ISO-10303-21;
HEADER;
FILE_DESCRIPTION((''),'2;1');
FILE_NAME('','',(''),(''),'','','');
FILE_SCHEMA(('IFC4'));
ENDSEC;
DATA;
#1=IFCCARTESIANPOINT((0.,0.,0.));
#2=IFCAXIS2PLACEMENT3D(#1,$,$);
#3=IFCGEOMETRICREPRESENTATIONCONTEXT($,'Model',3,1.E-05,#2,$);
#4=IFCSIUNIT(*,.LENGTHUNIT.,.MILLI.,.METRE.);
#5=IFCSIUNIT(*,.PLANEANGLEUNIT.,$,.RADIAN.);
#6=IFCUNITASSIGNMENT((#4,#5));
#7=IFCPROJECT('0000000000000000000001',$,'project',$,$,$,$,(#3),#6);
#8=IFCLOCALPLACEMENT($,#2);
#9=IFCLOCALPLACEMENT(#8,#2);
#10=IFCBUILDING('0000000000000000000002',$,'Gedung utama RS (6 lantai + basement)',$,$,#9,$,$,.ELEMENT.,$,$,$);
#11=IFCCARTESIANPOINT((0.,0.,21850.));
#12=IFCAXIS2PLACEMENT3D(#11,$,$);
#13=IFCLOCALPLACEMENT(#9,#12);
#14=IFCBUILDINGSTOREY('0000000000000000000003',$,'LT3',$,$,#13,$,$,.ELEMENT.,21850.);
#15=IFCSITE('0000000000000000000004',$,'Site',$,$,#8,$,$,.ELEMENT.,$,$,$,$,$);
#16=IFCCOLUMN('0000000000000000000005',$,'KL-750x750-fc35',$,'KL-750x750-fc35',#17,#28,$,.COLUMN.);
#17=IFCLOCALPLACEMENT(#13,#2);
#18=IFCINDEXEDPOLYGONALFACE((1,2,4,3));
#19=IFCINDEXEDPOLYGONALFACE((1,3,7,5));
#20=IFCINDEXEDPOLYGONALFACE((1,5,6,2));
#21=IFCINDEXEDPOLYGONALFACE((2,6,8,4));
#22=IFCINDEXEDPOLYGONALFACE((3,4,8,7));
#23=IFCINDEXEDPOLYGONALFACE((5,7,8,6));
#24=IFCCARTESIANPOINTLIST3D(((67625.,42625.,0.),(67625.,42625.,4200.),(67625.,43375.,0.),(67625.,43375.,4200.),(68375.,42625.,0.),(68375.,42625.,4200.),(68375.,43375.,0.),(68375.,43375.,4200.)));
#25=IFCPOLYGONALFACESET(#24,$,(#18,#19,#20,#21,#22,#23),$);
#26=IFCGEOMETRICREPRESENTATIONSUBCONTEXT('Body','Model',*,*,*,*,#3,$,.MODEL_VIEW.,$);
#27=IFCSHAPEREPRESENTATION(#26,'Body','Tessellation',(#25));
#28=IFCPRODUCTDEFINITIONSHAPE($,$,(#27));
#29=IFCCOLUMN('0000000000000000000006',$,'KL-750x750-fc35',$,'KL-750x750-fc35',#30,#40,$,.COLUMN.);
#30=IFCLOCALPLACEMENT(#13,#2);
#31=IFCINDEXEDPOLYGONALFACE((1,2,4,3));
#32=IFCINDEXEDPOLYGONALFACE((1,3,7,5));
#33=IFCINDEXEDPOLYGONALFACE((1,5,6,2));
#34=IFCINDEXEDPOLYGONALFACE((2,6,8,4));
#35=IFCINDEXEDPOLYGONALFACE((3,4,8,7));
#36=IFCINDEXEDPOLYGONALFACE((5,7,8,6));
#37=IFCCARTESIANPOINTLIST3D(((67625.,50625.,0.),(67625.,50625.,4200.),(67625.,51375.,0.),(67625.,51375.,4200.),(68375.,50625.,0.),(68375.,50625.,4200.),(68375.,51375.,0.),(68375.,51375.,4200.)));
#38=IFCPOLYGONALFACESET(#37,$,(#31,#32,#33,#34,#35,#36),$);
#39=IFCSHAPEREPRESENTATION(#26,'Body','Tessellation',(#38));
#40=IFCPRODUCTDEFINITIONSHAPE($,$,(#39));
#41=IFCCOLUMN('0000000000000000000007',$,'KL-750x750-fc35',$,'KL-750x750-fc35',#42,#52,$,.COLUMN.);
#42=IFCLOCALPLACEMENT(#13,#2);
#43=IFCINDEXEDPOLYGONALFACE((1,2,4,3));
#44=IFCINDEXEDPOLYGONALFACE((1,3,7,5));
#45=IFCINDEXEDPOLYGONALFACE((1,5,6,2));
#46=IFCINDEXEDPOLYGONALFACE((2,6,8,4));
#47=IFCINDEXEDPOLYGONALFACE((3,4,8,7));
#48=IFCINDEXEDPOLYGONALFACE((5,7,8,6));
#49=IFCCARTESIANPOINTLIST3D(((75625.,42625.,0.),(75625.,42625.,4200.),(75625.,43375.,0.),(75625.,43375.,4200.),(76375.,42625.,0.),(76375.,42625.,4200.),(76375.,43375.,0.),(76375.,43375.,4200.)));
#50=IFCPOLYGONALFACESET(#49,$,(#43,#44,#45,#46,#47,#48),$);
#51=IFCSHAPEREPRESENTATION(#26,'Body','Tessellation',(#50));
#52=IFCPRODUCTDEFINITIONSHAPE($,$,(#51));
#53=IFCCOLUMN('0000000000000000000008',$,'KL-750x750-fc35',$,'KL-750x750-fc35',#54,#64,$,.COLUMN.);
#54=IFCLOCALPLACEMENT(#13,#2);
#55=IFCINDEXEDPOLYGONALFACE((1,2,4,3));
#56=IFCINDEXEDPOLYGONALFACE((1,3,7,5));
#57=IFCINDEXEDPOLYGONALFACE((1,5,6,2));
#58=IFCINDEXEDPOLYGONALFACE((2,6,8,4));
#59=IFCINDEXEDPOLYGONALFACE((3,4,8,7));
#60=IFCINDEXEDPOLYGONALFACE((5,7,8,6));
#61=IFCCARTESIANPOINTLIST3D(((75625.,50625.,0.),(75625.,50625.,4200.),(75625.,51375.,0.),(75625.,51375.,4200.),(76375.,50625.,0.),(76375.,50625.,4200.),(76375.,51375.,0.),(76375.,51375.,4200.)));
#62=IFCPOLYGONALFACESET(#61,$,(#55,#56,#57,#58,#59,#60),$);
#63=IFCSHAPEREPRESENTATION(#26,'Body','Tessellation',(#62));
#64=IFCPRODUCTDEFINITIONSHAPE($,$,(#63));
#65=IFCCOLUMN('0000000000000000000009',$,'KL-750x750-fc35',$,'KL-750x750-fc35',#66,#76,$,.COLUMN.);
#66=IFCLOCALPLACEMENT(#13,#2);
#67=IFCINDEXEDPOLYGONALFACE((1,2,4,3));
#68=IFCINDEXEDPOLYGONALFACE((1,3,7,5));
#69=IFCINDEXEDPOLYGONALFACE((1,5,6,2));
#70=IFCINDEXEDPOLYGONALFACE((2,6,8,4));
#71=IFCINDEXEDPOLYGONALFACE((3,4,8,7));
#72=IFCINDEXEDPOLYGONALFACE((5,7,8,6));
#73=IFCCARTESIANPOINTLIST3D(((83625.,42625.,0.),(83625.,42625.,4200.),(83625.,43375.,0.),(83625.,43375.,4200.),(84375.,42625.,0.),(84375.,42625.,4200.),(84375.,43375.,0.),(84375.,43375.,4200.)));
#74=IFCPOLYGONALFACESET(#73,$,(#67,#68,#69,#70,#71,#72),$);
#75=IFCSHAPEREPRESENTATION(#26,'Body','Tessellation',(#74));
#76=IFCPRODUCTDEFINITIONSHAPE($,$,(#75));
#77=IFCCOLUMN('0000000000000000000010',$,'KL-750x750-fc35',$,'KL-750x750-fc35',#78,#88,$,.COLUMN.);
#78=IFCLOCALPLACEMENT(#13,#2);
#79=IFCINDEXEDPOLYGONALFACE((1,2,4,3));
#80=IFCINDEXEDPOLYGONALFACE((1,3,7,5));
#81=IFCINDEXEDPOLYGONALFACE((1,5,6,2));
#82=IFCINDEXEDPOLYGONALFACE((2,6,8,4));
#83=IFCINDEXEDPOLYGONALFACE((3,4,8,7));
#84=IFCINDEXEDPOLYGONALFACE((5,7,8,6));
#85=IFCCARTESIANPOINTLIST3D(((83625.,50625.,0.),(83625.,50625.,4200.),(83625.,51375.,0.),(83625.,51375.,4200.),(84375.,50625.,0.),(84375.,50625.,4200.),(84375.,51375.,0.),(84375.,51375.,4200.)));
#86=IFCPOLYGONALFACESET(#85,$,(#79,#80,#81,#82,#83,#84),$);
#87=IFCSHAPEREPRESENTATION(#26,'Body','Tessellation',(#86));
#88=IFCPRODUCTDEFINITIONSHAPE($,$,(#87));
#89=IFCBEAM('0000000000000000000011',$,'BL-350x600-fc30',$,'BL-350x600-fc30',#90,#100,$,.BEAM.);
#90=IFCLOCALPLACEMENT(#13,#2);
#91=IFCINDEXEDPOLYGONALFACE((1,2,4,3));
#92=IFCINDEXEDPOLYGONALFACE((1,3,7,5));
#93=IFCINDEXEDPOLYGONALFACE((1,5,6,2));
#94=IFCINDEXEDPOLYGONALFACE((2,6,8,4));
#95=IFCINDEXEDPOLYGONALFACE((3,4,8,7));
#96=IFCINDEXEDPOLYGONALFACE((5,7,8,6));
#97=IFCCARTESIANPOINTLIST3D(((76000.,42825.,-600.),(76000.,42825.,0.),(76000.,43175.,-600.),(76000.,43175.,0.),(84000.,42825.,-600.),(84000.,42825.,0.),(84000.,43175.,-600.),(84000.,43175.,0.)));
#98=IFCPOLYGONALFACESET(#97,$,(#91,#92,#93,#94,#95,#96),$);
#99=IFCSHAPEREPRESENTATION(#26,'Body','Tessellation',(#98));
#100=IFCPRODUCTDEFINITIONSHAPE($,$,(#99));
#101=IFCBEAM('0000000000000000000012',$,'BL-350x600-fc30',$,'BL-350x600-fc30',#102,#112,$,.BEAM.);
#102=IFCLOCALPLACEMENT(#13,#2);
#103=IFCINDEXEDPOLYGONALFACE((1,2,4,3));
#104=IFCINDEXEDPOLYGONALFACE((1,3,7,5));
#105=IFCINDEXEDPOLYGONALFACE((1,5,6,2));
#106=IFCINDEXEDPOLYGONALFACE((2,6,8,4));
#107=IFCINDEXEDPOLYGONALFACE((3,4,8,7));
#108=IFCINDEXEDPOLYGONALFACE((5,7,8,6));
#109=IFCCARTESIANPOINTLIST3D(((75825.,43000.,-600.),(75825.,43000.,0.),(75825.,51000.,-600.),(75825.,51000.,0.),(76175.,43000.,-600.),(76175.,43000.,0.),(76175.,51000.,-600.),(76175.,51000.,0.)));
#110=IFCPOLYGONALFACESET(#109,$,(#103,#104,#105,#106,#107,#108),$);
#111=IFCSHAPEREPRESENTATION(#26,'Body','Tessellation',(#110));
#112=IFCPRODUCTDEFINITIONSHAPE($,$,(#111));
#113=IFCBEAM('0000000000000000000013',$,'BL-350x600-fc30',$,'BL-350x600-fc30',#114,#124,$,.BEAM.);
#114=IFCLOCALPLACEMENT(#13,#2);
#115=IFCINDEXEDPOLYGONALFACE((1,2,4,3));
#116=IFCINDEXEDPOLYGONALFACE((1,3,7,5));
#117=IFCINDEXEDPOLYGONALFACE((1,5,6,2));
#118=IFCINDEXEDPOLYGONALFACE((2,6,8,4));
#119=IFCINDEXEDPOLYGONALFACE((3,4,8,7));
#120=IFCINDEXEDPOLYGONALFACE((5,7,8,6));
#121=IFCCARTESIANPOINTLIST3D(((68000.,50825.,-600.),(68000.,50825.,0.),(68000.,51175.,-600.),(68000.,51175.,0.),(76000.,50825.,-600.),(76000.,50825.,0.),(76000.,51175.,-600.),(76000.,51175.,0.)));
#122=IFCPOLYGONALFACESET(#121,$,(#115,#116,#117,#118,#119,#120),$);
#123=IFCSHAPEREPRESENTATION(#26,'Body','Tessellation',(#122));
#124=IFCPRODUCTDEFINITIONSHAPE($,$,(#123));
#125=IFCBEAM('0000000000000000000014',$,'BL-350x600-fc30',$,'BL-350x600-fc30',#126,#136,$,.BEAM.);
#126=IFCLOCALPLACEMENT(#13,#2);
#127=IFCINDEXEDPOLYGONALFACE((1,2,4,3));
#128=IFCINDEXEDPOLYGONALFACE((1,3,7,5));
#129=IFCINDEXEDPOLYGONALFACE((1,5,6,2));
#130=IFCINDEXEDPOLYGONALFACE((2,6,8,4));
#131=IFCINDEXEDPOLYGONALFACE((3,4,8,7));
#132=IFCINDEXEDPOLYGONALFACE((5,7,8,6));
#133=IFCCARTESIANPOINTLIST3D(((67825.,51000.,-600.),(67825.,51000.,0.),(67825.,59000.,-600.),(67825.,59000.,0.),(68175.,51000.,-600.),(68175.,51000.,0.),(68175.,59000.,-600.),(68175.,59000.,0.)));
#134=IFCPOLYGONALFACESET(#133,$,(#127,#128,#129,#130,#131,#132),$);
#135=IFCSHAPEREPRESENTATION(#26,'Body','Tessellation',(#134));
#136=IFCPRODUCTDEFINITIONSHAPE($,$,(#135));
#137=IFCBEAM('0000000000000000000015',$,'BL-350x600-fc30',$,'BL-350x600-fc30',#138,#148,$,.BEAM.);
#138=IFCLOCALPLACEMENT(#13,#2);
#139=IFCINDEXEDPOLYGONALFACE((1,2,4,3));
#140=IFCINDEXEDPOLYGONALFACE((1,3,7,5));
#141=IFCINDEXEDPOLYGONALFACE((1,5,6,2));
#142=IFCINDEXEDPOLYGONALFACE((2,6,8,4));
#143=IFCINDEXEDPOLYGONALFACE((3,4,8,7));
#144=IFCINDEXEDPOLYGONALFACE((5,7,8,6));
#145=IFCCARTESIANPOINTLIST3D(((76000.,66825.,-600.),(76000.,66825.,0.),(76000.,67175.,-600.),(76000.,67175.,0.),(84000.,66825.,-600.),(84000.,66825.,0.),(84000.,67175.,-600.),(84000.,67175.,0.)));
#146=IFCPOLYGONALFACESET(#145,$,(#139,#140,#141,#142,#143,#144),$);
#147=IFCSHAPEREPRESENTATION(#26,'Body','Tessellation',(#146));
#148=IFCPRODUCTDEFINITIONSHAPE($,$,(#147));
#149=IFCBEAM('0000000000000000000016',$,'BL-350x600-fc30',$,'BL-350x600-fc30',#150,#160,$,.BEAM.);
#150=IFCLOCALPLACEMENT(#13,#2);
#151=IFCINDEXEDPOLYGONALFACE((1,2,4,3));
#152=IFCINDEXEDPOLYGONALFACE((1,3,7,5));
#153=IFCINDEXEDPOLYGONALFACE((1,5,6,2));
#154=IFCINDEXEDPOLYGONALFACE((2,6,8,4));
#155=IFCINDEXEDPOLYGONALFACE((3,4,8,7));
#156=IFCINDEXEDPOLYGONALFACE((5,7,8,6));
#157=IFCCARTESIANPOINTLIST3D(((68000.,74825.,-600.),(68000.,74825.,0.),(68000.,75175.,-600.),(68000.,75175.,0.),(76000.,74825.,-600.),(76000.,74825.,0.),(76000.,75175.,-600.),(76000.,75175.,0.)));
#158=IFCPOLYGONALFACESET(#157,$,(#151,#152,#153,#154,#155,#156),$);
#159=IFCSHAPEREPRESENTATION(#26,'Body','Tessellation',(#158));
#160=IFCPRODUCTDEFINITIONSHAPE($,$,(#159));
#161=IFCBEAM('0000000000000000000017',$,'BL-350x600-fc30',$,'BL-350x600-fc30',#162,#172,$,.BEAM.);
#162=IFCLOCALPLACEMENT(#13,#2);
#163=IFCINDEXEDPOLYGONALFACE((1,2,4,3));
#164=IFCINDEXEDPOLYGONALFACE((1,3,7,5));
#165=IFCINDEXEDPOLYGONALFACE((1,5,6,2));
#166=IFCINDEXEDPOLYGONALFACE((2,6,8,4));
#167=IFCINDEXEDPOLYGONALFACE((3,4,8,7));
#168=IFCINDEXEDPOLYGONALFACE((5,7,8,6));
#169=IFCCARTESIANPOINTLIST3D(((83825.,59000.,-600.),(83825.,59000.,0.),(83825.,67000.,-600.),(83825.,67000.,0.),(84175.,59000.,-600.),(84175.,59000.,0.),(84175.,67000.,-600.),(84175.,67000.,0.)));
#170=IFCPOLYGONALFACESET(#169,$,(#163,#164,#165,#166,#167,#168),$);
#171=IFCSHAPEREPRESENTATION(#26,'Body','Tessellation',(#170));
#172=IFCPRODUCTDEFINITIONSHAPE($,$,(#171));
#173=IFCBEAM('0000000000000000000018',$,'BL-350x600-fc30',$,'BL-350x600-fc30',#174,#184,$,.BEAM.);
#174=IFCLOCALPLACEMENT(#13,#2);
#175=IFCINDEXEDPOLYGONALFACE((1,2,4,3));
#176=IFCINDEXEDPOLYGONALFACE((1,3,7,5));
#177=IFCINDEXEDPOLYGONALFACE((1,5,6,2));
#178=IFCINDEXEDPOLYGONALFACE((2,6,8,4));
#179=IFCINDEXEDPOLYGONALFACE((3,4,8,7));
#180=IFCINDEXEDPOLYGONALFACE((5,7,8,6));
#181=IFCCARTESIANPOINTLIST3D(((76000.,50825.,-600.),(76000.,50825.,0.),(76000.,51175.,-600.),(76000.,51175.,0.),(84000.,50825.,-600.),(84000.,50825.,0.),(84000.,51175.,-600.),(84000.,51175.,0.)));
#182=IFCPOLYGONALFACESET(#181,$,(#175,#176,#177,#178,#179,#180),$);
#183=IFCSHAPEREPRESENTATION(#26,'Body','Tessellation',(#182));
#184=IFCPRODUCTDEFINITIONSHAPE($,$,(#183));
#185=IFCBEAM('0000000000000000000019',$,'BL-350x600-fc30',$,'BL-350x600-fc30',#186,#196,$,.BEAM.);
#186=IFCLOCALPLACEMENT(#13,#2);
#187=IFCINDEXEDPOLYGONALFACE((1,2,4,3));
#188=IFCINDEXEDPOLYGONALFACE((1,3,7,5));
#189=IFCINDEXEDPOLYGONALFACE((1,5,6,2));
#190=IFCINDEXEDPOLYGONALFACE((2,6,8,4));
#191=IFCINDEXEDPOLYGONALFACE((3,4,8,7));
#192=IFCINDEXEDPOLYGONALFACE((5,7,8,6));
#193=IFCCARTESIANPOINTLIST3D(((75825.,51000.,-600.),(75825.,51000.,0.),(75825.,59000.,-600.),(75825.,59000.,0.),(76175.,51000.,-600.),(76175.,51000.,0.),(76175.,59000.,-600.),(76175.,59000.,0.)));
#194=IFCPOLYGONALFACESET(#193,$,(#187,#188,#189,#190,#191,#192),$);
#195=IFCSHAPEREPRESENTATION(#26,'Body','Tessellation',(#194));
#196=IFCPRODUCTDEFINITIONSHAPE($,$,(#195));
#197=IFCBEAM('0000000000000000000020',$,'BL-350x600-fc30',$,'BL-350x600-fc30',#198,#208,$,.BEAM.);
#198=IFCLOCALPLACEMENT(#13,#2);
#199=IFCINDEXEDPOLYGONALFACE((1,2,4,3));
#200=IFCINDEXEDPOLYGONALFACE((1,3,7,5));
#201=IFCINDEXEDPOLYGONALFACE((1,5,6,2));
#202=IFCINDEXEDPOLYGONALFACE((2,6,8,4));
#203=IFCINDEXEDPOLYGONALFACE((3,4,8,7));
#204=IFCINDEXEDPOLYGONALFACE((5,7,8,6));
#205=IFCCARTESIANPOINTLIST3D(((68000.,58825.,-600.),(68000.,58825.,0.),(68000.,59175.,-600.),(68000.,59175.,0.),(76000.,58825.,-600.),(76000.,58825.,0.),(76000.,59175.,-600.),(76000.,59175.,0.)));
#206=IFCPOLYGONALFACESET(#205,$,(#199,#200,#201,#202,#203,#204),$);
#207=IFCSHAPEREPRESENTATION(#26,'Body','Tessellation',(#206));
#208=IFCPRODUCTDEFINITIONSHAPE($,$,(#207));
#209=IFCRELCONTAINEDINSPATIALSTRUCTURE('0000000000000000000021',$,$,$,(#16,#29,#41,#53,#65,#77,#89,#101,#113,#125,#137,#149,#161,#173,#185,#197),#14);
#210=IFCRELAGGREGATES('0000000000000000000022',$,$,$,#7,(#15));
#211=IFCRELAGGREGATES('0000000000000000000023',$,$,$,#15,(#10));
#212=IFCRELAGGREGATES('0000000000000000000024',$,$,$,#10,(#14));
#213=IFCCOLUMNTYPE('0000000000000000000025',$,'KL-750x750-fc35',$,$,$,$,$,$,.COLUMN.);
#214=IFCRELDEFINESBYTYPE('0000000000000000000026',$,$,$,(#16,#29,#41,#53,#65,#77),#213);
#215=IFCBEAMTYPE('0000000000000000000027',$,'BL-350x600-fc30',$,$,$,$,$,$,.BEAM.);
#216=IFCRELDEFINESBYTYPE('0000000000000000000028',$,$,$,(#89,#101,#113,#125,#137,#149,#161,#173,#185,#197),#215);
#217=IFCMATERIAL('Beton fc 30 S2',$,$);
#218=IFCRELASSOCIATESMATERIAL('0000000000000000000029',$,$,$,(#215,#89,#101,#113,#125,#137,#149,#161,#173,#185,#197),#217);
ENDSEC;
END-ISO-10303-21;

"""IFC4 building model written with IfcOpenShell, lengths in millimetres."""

from ifc_helpers import new_model, si_unit, frame, origin, origin_2d, place, context, subcontext, project, spatial, rectangle, extrude, material, material_profile, profile_set, profile_usage, type_object, element, save


model = new_model("IFC4")

# Units and contexts
model_context = context("Model", 3, precision=1e-05, world=origin())
body_context = subcontext(model_context, "Body", "Model", "MODEL_VIEW")
ifc_project = project(units=[si_unit("LENGTHUNIT", "METRE", prefix="MILLI"), si_unit("PLANEANGLEUNIT", "RADIAN")], contexts=[model_context])

# Site, building, storey
site_placement = place(None, origin())
site = spatial("IfcSite", under=ifc_project, at=site_placement, Name="Site", CompositionType="ELEMENT")
building_placement = place(site_placement, origin())
building = spatial("IfcBuilding", under=site, at=building_placement, Name="Gedung utama RS (6 lantai + basement)", CompositionType="ELEMENT")
storey_placement = place(building_placement, frame((0.0, 0.0, 21850.0)))
storey = spatial("IfcBuildingStorey", under=building, at=storey_placement, Name="LT3", CompositionType="ELEMENT", Elevation=21850.0)

# Columns
ifc_material_profile_1 = material_profile(None, rectangle(XDim=750.0, YDim=750.0, at=origin_2d()), Name="KL-750x750-fc35")
ifc_profile_set_1 = profile_set([ifc_material_profile_1], Name="KL-750x750-fc35")
ifc_profile_usage_1 = profile_usage(ifc_profile_set_1, cardinal=5)
column_type = type_object("IfcColumnType", Name="KL-750x750-fc35", PredefinedType="COLUMN", material=ifc_profile_set_1)
for number, where, z_axis, x_axis, name in (
    (1, (68000.0, 43000.0, 0.0), (0.0, 0.0, 1.0), (1.0, 0.0, 0.0), "KL-750x750-fc35"),
    (2, (68000.0, 51000.0, 0.0), (0.0, 0.0, 1.0), (1.0, 0.0, 0.0), "KL-750x750-fc35"),
    (3, (76000.0, 43000.0, 0.0), (0.0, 0.0, 1.0), (1.0, 0.0, 0.0), "KL-750x750-fc35"),
    (4, (76000.0, 51000.0, 0.0), (0.0, 0.0, 1.0), (1.0, 0.0, 0.0), "KL-750x750-fc35"),
    (5, (84000.0, 43000.0, 0.0), (0.0, 0.0, 1.0), (1.0, 0.0, 0.0), "KL-750x750-fc35"),
    (6, (84000.0, 51000.0, 0.0), (0.0, 0.0, 1.0), (1.0, 0.0, 0.0), "KL-750x750-fc35"),
):
    element("IfcColumn", number, at=place(storey_placement, frame(where, z_axis=z_axis, x_axis=x_axis)), inside=storey, type_object=column_type, material=ifc_profile_usage_1, Name=name, ObjectType="KL-750x750-fc35", PredefinedType="COLUMN", context=body_context, shape_type="SweptSolid", body=[
        extrude(rectangle(XDim=750.0, YDim=750.0, at=origin_2d()), origin(), (0.0, 0.0, 1.0), 4200.0),
    ])

# Beams
ifc_material_1 = material(Name="Beton fc 30 S2")
ifc_material_profile_2 = material_profile(ifc_material_1, rectangle(XDim=350.0, YDim=600.0, at=origin_2d()), Name="BL-350x600-fc30")
ifc_profile_set_2 = profile_set([ifc_material_profile_2], Name="BL-350x600-fc30")
ifc_profile_usage_2 = profile_usage(ifc_profile_set_2, cardinal=8)
beam_type_1 = type_object("IfcBeamType", Name="BL-350x600-fc30", PredefinedType="BEAM", material=ifc_profile_set_2)
beam_1_placement = place(storey_placement, frame((76000.0, 43000.0, -300.0)))
element("IfcBeam", 7, at=beam_1_placement, inside=storey, type_object=beam_type_1, material=ifc_profile_usage_2, Name="BL-350x600-fc30", ObjectType="BL-350x600-fc30", PredefinedType="BEAM", context=body_context, shape_type="SweptSolid", body=[
    extrude(rectangle(XDim=350.0, YDim=600.0, at=origin_2d()), frame((0.0, 0.0, 0.0), z_axis=(1.0, 0.0, 0.0), x_axis=(0.0, 1.0, 0.0)), (0.0, 0.0, 1.0), 8000.0),
])
beam_2_placement = place(storey_placement, frame((76000.0, 43000.0, -300.0)))
element("IfcBeam", 8, at=beam_2_placement, inside=storey, type_object=beam_type_1, material=ifc_profile_usage_2, Name="BL-350x600-fc30", ObjectType="BL-350x600-fc30", PredefinedType="BEAM", context=body_context, shape_type="SweptSolid", body=[
    extrude(rectangle(XDim=350.0, YDim=600.0, at=origin_2d()), frame((0.0, 0.0, 0.0), z_axis=(0.0, 1.0, 0.0), x_axis=(-1.0, 0.0, 0.0)), (0.0, 0.0, 1.0), 8000.0),
])
beam_3_placement = place(storey_placement, frame((68000.0, 51000.0, -300.0)))
element("IfcBeam", 9, at=beam_3_placement, inside=storey, type_object=beam_type_1, material=ifc_profile_usage_2, Name="BL-350x600-fc30", ObjectType="BL-350x600-fc30", PredefinedType="BEAM", context=body_context, shape_type="SweptSolid", body=[
    extrude(rectangle(XDim=350.0, YDim=600.0, at=origin_2d()), frame((0.0, 0.0, 0.0), z_axis=(1.0, 0.0, 0.0), x_axis=(0.0, 1.0, 0.0)), (0.0, 0.0, 1.0), 8000.0),
])
beam_4_placement = place(storey_placement, frame((68000.0, 51000.0, -300.0)))
element("IfcBeam", 10, at=beam_4_placement, inside=storey, type_object=beam_type_1, material=ifc_profile_usage_2, Name="BL-350x600-fc30", ObjectType="BL-350x600-fc30", PredefinedType="BEAM", context=body_context, shape_type="SweptSolid", body=[
    extrude(rectangle(XDim=350.0, YDim=600.0, at=origin_2d()), frame((0.0, 0.0, 0.0), z_axis=(0.0, 1.0, 0.0), x_axis=(-1.0, 0.0, 0.0)), (0.0, 0.0, 1.0), 8000.0),
])
for number, where, name in (
    (11, (76000.0, 67000.0, -300.0), "BL-350x600-fc30"),
    (12, (68000.0, 75000.0, -300.0), "BL-350x600-fc30"),
):
    element("IfcBeam", number, at=place(storey_placement, frame(where)), inside=storey, type_object=beam_type_1, material=ifc_profile_usage_2, Name=name, ObjectType="BL-350x600-fc30", PredefinedType="BEAM", context=body_context, shape_type="SweptSolid", body=[
        extrude(rectangle(XDim=350.0, YDim=600.0, at=origin_2d()), frame((0.0, 0.0, 0.0), z_axis=(1.0, 0.0, 0.0), x_axis=(0.0, 1.0, 0.0)), (0.0, 0.0, 1.0), 8000.0),
    ])
beam_5_placement = place(storey_placement, frame((84000.0, 59000.0, -300.0)))
element("IfcBeam", 13, at=beam_5_placement, inside=storey, type_object=beam_type_1, material=ifc_profile_usage_2, Name="BL-350x600-fc30", ObjectType="BL-350x600-fc30", PredefinedType="BEAM", context=body_context, shape_type="SweptSolid", body=[
    extrude(rectangle(XDim=350.0, YDim=600.0, at=origin_2d()), frame((0.0, 0.0, 0.0), z_axis=(0.0, 1.0, 0.0), x_axis=(-1.0, 0.0, 0.0)), (0.0, 0.0, 1.0), 8000.0),
])
beam_6_placement = place(storey_placement, frame((76000.0, 51000.0, -300.0)))
element("IfcBeam", 14, at=beam_6_placement, inside=storey, type_object=beam_type_1, material=ifc_profile_usage_2, Name="BL-350x600-fc30", ObjectType="BL-350x600-fc30", PredefinedType="BEAM", context=body_context, shape_type="SweptSolid", body=[
    extrude(rectangle(XDim=350.0, YDim=600.0, at=origin_2d()), frame((0.0, 0.0, 0.0), z_axis=(1.0, 0.0, 0.0), x_axis=(0.0, 1.0, 0.0)), (0.0, 0.0, 1.0), 8000.0),
])
beam_7_placement = place(storey_placement, frame((76000.0, 51000.0, -300.0)))
element("IfcBeam", 15, at=beam_7_placement, inside=storey, type_object=beam_type_1, material=ifc_profile_usage_2, Name="BL-350x600-fc30", ObjectType="BL-350x600-fc30", PredefinedType="BEAM", context=body_context, shape_type="SweptSolid", body=[
    extrude(rectangle(XDim=350.0, YDim=600.0, at=origin_2d()), frame((0.0, 0.0, 0.0), z_axis=(0.0, 1.0, 0.0), x_axis=(-1.0, 0.0, 0.0)), (0.0, 0.0, 1.0), 8000.0),
])
beam_8_placement = place(storey_placement, frame((68000.0, 59000.0, -300.0)))
element("IfcBeam", 16, at=beam_8_placement, inside=storey, type_object=beam_type_1, material=ifc_profile_usage_2, Name="BL-350x600-fc30", ObjectType="BL-350x600-fc30", PredefinedType="BEAM", context=body_context, shape_type="SweptSolid", body=[
    extrude(rectangle(XDim=350.0, YDim=600.0, at=origin_2d()), frame((0.0, 0.0, 0.0), z_axis=(1.0, 0.0, 0.0), x_axis=(0.0, 1.0, 0.0)), (0.0, 0.0, 1.0), 8000.0),
])

save(model, "model.ifc")
